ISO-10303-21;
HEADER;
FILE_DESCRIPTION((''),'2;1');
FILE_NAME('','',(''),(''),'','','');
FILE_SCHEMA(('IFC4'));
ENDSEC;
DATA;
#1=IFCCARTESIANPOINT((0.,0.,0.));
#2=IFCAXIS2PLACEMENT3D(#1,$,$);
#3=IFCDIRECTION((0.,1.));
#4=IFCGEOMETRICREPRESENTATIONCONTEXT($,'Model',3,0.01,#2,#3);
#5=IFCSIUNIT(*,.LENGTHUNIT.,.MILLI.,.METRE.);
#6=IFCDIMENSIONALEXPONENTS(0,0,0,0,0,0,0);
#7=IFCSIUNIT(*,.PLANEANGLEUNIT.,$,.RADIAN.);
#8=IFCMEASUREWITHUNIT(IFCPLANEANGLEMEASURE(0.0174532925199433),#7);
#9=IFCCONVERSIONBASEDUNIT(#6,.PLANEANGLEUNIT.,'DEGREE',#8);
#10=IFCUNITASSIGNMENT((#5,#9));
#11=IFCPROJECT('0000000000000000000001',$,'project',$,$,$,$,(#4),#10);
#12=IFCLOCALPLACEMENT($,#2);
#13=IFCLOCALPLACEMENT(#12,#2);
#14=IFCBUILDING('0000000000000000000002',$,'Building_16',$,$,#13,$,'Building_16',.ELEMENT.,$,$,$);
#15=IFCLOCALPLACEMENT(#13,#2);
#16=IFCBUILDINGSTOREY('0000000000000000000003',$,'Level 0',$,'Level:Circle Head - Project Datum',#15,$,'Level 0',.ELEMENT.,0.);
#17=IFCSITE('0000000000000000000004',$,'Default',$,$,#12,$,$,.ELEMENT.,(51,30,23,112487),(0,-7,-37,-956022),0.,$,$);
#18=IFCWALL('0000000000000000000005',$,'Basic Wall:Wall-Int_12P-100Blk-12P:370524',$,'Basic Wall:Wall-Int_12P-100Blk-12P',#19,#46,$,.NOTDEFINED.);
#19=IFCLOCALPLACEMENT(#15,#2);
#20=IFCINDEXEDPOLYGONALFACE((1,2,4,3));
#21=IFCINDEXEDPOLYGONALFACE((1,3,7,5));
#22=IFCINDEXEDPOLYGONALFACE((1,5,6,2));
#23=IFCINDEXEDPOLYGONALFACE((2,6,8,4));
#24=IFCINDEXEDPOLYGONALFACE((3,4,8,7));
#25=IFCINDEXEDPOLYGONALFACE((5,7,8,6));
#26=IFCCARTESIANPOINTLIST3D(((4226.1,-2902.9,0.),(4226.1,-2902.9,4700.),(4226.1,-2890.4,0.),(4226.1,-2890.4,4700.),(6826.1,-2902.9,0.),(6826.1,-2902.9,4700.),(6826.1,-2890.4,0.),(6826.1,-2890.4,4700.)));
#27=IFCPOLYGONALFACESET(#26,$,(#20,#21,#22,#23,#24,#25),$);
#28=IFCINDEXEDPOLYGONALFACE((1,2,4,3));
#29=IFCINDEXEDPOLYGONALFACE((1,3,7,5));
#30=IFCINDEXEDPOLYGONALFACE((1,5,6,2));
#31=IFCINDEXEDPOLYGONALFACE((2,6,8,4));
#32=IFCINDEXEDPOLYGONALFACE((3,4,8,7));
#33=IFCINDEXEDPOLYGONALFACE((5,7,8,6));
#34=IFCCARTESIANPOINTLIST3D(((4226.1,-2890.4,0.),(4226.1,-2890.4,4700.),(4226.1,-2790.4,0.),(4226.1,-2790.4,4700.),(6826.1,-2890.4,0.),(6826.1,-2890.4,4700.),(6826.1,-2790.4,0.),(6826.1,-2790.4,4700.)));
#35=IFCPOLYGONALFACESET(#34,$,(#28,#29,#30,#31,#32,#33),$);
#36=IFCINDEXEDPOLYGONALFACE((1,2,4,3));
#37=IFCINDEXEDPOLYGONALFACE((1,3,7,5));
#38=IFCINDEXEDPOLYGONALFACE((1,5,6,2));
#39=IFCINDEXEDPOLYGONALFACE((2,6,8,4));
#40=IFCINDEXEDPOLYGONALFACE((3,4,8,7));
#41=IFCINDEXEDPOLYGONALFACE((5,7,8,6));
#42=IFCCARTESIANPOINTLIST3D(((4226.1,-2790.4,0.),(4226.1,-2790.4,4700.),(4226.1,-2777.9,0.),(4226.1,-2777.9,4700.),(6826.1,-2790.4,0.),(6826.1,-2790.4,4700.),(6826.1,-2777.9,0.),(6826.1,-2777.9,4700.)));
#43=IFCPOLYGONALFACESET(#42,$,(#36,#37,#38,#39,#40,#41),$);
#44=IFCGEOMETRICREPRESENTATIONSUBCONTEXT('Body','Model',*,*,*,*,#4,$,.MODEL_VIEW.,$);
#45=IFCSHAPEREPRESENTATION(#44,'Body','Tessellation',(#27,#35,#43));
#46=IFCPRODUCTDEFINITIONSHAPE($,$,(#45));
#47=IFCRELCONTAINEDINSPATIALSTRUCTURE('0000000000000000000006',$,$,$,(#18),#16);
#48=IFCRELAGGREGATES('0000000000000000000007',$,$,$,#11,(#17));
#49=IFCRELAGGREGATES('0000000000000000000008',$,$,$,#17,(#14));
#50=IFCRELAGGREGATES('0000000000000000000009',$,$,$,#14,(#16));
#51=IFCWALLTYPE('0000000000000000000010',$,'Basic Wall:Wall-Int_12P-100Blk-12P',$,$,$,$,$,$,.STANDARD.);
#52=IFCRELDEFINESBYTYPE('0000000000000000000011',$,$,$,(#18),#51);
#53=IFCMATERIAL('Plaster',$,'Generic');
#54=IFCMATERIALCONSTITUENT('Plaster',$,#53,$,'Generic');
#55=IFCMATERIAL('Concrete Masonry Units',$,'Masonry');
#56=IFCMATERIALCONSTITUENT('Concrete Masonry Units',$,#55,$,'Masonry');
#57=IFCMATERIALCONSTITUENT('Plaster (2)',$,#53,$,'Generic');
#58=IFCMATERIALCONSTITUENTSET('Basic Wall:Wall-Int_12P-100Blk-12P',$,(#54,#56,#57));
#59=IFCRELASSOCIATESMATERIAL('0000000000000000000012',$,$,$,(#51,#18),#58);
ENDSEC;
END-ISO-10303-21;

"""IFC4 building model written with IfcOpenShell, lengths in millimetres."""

from ifc_helpers import new_model, entity, si_unit, converted_unit, direction, frame, origin, place, context, subcontext, project, spatial, indexed_curve, outline, extrude, material, constituent, constituent_set, type_object, element, save


model = new_model("IFC4")

# Units and contexts
model_context = context("Model", 3, precision=0.01, world=origin(), true_north=direction((0.0, 1.0)))
body_context = subcontext(model_context, "Body", "Model", "MODEL_VIEW")
ifc_project = project(units=[si_unit("LENGTHUNIT", "METRE", prefix="MILLI"), converted_unit("PLANEANGLEUNIT", "DEGREE", entity("IfcPlaneAngleMeasure", 0.0174532925199433), si_unit("PLANEANGLEUNIT", "RADIAN"), dimensions=[0, 0, 0, 0, 0, 0, 0])], contexts=[model_context])

# Site, building, storey
site_placement = place(None, origin())
site = spatial("IfcSite", under=ifc_project, at=site_placement, Name="Default", CompositionType="ELEMENT", RefLatitude=(51, 30, 23, 112487), RefLongitude=(0, -7, -37, -956022), RefElevation=0.0)
building_placement = place(site_placement, origin())
building = spatial("IfcBuilding", under=site, at=building_placement, Name="Building_16", LongName="Building_16", CompositionType="ELEMENT")
storey_placement = place(building_placement, origin())
storey = spatial("IfcBuildingStorey", under=building, at=storey_placement, Name="Level 0", ObjectType="Level:Circle Head - Project Datum", LongName="Level 0", CompositionType="ELEMENT", Elevation=0.0)

# Shared definitions
ifc_material_1 = material(Name="Plaster", Category="Generic")
ifc_constituent_1 = constituent(ifc_material_1, Name="Plaster", Category="Generic")
ifc_material_2 = material(Name="Concrete Masonry Units", Category="Masonry")
ifc_constituent_2 = constituent(ifc_material_2, Name="Concrete Masonry Units", Category="Masonry")
ifc_constituent_3 = constituent(ifc_material_1, Name="Plaster (2)", Category="Generic")
ifc_constituent_set = constituent_set(constituents=[ifc_constituent_1, ifc_constituent_2, ifc_constituent_3], Name="Basic Wall:Wall-Int_12P-100Blk-12P")
wall_type = type_object("IfcWallType", Name="Basic Wall:Wall-Int_12P-100Blk-12P", PredefinedType="STANDARD", material=ifc_constituent_set)

# Wall
wall_1_placement = place(storey_placement, frame((4226.1, -2840.4, 0.0)))
element("IfcWall", 1, at=wall_1_placement, inside=storey, type_object=wall_type, material=ifc_constituent_set, Name="Basic Wall:Wall-Int_12P-100Blk-12P:370524", ObjectType="Basic Wall:Wall-Int_12P-100Blk-12P", PredefinedType="NOTDEFINED", context=body_context, shape_type="SweptSolid", body=[
    extrude(outline(indexed_curve([(-6.3, -1300.0), (6.2, -1300.0), (6.3, 1300.0), (-6.2, 1300.0), (-6.3, -1300.0)], self_intersect=False)), frame((1300.0, -56.3, 0.0), z_axis=(0.0, 0.0, 1.0), x_axis=(0.0, 1.0, 0.0)), (0.0, 0.0, 1.0), 4700.0),
    extrude(outline(indexed_curve([(-1300.0, -50.0), (1300.0, -50.0), (1300.0, 50.0), (-1300.0, 50.0), (-1300.0, -50.0)], self_intersect=False)), frame((1300.0, 0.0, 0.0)), (0.0, 0.0, 1.0), 4700.0),
    extrude(outline(indexed_curve([(-6.3, -1300.0), (6.2, -1300.0), (6.3, 1300.0), (-6.2, 1300.0), (-6.3, -1300.0)], self_intersect=False)), frame((1300.0, 56.3, 0.0), z_axis=(0.0, 0.0, 1.0), x_axis=(0.0, -1.0, 0.0)), (0.0, 0.0, 1.0), 4700.0),
])

save(model, "model.ifc")
